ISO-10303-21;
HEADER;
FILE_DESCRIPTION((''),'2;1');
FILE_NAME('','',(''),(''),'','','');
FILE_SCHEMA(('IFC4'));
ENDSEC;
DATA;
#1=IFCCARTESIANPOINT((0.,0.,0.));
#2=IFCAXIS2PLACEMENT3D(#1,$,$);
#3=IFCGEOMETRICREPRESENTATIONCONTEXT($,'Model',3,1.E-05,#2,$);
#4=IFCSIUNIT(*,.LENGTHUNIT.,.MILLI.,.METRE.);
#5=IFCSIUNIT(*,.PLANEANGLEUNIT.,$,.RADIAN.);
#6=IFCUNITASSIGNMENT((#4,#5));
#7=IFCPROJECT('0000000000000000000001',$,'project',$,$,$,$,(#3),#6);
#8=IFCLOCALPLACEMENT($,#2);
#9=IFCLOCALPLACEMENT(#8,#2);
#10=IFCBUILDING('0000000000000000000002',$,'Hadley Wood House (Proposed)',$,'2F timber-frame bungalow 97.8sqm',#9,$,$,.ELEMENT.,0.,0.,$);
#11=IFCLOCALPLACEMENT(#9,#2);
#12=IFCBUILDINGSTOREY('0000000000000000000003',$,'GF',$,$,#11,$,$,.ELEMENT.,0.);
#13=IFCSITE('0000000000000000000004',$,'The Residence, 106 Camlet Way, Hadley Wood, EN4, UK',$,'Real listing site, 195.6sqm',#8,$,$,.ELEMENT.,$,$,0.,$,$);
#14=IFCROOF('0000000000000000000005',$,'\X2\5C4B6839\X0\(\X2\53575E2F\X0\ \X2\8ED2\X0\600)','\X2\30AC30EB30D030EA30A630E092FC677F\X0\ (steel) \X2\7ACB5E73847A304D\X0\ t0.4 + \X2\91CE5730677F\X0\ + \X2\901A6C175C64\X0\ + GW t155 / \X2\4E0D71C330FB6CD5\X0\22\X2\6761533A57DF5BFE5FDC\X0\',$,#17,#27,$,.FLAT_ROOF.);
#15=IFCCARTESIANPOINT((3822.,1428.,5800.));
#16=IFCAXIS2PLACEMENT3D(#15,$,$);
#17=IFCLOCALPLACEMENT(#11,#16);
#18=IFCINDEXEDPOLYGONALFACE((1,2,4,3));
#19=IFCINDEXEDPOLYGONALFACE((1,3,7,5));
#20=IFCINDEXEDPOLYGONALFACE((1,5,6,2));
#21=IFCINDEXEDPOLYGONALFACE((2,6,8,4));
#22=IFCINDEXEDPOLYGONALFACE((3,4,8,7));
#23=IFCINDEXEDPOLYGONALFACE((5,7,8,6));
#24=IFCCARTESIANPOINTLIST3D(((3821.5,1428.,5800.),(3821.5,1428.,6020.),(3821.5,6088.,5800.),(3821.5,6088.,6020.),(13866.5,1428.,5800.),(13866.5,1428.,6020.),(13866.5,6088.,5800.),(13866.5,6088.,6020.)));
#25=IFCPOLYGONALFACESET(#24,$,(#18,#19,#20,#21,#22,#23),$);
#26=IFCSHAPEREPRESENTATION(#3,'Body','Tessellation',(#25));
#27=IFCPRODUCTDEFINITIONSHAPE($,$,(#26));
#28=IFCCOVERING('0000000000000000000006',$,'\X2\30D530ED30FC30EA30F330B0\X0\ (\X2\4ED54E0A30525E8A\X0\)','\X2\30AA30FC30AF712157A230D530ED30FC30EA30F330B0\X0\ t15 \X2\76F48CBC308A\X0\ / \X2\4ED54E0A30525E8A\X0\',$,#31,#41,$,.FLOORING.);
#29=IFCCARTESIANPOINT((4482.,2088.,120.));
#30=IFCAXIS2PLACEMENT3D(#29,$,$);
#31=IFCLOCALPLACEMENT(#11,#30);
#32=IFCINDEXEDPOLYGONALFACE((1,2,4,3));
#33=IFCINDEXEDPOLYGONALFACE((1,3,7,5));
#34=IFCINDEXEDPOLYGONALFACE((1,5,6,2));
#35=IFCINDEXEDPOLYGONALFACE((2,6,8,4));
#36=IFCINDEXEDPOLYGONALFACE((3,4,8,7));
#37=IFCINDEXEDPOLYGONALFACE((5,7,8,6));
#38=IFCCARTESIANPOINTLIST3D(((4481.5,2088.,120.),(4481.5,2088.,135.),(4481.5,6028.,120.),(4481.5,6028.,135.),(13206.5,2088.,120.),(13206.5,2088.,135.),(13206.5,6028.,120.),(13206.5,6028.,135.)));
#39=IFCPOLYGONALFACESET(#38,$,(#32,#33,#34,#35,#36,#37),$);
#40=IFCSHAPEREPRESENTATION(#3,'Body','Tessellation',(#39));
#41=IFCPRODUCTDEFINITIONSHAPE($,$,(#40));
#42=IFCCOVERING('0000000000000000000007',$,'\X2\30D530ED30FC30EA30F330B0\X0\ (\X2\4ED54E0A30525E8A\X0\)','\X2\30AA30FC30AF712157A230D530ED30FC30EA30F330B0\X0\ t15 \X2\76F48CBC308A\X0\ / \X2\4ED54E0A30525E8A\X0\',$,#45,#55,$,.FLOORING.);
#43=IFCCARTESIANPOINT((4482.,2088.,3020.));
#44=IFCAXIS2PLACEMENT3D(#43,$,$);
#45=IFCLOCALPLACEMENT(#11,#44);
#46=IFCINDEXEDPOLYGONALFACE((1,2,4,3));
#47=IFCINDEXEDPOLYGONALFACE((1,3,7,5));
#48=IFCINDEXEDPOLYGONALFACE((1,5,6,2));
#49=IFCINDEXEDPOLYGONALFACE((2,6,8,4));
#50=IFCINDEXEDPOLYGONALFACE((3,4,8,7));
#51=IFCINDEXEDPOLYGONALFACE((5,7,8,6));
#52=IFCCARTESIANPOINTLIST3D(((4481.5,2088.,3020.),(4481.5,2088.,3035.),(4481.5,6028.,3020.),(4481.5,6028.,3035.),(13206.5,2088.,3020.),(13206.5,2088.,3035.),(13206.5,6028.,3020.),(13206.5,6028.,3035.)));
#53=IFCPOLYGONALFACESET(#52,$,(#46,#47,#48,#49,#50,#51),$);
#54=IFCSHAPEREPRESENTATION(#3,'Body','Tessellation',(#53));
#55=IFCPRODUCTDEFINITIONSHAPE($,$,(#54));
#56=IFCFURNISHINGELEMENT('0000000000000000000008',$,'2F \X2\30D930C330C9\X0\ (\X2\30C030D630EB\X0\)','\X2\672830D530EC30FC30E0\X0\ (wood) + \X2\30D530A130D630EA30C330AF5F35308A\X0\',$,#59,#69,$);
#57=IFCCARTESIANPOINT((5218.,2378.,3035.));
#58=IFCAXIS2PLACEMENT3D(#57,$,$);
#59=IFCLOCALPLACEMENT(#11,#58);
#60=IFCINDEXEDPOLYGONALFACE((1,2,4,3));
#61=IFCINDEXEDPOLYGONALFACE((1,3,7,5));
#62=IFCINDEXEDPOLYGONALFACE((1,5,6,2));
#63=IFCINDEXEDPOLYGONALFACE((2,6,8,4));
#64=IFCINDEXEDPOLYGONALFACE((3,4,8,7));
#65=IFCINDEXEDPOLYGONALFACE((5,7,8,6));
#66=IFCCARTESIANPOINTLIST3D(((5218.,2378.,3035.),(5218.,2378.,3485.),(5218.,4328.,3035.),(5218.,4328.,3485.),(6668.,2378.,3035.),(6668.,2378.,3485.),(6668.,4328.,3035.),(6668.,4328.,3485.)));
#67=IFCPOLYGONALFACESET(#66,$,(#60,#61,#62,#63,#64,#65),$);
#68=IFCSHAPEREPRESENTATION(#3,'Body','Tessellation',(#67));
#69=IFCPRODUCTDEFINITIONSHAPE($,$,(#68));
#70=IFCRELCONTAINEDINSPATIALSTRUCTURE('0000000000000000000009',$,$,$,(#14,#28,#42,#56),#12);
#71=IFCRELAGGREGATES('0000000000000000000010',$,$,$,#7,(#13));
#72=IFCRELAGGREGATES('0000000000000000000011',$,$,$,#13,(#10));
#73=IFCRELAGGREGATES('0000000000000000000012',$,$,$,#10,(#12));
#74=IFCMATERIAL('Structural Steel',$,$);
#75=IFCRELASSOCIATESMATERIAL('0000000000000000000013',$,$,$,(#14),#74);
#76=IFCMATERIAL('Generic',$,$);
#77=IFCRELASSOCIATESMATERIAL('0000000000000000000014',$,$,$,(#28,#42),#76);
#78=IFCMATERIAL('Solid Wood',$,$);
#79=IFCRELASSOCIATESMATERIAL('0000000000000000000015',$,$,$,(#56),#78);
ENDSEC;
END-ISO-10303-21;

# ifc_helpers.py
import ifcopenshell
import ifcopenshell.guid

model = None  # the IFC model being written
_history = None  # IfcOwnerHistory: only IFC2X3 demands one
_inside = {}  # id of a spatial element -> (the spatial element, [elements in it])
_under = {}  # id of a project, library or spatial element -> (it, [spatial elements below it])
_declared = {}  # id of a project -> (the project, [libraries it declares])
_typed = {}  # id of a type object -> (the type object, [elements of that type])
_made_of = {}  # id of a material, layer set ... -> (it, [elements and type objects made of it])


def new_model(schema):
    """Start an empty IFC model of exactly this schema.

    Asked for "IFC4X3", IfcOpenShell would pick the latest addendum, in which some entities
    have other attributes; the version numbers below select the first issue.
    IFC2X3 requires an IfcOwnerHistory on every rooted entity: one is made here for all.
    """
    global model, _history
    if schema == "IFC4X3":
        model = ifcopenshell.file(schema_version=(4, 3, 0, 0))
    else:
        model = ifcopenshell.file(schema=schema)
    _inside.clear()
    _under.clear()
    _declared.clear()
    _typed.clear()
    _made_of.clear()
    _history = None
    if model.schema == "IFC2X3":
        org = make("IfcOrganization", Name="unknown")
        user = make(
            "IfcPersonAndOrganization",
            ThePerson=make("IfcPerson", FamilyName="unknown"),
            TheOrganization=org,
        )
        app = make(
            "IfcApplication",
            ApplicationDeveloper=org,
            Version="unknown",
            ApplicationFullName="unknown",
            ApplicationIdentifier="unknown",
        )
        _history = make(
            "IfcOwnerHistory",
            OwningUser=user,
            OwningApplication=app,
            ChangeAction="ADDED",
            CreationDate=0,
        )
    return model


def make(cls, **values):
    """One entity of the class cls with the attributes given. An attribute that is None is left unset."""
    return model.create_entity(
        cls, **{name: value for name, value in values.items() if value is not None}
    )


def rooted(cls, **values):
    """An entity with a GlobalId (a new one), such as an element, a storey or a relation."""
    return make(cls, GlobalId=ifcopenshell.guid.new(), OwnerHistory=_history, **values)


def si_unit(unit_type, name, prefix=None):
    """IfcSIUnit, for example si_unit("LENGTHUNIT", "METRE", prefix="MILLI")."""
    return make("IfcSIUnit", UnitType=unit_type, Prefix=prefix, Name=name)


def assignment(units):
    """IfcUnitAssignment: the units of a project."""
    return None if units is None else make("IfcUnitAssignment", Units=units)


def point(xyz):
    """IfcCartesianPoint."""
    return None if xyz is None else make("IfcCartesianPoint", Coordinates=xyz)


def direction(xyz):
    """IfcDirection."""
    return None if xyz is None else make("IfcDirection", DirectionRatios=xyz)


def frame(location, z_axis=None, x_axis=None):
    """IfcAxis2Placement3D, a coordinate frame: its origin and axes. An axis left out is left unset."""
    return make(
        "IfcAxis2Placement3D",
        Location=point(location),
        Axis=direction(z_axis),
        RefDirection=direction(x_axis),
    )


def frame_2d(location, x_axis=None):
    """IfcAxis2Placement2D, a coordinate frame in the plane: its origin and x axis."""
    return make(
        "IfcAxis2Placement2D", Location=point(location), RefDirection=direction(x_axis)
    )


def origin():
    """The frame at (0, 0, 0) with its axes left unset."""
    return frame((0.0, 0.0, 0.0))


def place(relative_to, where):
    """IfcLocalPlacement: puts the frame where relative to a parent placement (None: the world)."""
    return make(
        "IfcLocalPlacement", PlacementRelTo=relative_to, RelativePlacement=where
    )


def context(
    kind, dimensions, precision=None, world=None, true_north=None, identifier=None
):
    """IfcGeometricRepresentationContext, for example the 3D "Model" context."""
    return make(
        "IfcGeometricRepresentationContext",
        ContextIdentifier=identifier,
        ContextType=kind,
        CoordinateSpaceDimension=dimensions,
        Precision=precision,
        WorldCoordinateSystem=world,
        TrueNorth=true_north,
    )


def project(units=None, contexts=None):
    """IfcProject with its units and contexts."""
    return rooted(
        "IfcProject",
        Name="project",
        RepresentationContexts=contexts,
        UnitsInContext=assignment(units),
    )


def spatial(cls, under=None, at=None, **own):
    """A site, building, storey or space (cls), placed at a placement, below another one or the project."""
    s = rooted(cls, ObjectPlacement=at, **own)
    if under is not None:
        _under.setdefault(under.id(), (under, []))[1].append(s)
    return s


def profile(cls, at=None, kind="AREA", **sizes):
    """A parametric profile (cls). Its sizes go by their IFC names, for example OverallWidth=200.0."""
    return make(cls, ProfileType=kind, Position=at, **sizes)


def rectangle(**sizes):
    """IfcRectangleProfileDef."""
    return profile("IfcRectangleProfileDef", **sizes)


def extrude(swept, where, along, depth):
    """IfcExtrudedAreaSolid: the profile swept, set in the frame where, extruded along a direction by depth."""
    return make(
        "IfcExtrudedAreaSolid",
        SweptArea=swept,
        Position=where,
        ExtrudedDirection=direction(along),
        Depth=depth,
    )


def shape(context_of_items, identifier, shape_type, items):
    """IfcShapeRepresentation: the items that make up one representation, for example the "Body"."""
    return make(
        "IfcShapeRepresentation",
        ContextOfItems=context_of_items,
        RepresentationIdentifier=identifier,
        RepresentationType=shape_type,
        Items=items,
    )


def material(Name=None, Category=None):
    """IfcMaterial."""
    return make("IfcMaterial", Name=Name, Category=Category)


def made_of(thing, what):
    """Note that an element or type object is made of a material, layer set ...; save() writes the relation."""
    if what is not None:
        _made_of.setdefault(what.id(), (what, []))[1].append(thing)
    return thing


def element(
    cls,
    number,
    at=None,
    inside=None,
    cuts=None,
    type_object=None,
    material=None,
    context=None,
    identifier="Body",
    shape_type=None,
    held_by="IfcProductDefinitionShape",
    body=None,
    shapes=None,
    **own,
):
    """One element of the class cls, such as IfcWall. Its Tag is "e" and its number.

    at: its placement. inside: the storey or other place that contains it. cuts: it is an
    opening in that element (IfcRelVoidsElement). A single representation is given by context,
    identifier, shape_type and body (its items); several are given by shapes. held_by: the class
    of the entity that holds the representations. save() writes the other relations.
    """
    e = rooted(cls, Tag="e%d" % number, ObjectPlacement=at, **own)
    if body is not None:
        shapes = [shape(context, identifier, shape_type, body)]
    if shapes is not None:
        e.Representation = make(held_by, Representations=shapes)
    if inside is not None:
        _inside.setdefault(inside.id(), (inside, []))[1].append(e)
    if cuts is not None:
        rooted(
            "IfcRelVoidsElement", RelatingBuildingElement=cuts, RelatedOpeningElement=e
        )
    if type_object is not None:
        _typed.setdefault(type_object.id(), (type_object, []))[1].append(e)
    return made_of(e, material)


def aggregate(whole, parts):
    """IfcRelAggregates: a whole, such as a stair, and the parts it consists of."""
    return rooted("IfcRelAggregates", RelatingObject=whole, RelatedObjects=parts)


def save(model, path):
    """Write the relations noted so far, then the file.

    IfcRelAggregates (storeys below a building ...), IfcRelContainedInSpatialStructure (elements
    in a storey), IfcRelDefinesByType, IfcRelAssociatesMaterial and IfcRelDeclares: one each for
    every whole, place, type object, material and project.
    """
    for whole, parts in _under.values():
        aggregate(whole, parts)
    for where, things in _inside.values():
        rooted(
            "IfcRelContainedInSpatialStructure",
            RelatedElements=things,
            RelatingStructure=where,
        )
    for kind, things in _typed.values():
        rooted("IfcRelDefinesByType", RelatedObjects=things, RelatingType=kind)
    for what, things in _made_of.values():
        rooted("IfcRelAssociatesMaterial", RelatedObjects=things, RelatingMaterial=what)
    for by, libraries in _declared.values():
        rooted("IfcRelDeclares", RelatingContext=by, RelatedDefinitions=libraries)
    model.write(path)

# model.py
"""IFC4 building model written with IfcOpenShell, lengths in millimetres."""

from ifc_helpers import new_model, si_unit, frame, frame_2d, origin, place, context, project, spatial, rectangle, extrude, material, element, save


model = new_model("IFC4")

# Units and contexts
model_context = context("Model", 3, precision=1e-05, world=origin())
ifc_project = project(units=[si_unit("LENGTHUNIT", "METRE", prefix="MILLI"), si_unit("PLANEANGLEUNIT", "RADIAN")], contexts=[model_context])

# Site, building, storey
site_placement = place(None, origin())
site = spatial("IfcSite", under=ifc_project, at=site_placement, Name="The Residence, 106 Camlet Way, Hadley Wood, EN4, UK", ObjectType="Real listing site, 195.6sqm", CompositionType="ELEMENT", RefElevation=0.0)
building_placement = place(site_placement, origin())
building = spatial("IfcBuilding", under=site, at=building_placement, Name="Hadley Wood House (Proposed)", ObjectType="2F timber-frame bungalow 97.8sqm", CompositionType="ELEMENT", ElevationOfRefHeight=0.0, ElevationOfTerrain=0.0)
storey_placement = place(building_placement, origin())
storey = spatial("IfcBuildingStorey", under=building, at=storey_placement, Name="GF", CompositionType="ELEMENT", Elevation=0.0)

# Shared definitions
ifc_material_1 = material(Name="Solid Wood")

# Roof
ifc_material_2 = material(Name="Structural Steel")
for number, where, name in (
    (1, (3822.0, 1428.0, 5800.0), "屋根(南帯 軒600)"),
):
    element("IfcRoof", number, at=place(storey_placement, frame(where)), inside=storey, material=ifc_material_2, Name=name, Description="ガルバリウム鋼板 (steel) 立平葺き t0.4 + 野地板 + 通気層 + GW t155 / 不燃・法22条区域対応", PredefinedType="FLAT_ROOF", context=model_context, shape_type="SweptSolid", body=[
        extrude(rectangle(XDim=10045.0, YDim=4660.0, at=frame_2d((5022.0, 2330.0))), frame((3822.0, 1428.0, 5800.0)), (0.0, 0.0, 1.0), 220.0),
    ])

# Coverings
ifc_material_3 = material(Name="Generic")
covering_1_placement = place(storey_placement, frame((4482.0, 2088.0, 120.0)))
element("IfcCovering", 2, at=covering_1_placement, inside=storey, material=ifc_material_3, Name="フローリング (仕上げ床)", Description="オーク無垢フローリング t15 直貼り / 仕上げ床", PredefinedType="FLOORING", context=model_context, shape_type="SweptSolid", body=[
    extrude(rectangle(XDim=8725.0, YDim=3940.0, at=frame_2d((4362.0, 1970.0))), frame((4482.0, 2088.0, 120.0)), (0.0, 0.0, 1.0), 15.0),
])
covering_2_placement = place(storey_placement, frame((4482.0, 2088.0, 3020.0)))
element("IfcCovering", 3, at=covering_2_placement, inside=storey, material=ifc_material_3, Name="フローリング (仕上げ床)", Description="オーク無垢フローリング t15 直貼り / 仕上げ床", PredefinedType="FLOORING", context=model_context, shape_type="SweptSolid", body=[
    extrude(rectangle(XDim=8725.0, YDim=3940.0, at=frame_2d((4362.0, 1970.0))), frame((4482.0, 2088.0, 3020.0)), (0.0, 0.0, 1.0), 15.0),
])

# Furnishing element
furnishing_placement = place(storey_placement, frame((5218.0, 2378.0, 3035.0)))
element("IfcFurnishingElement", 4, at=furnishing_placement, inside=storey, material=ifc_material_1, Name="2F ベッド (ダブル)", Description="木フレーム (wood) + ファブリック張り", context=model_context, shape_type="SweptSolid", body=[
    extrude(rectangle(XDim=1450.0, YDim=1950.0, at=frame_2d((725.0, 975.0))), frame((5218.0, 2378.0, 3035.0)), (0.0, 0.0, 1.0), 450.0),
])

save(model, "model.ifc")
